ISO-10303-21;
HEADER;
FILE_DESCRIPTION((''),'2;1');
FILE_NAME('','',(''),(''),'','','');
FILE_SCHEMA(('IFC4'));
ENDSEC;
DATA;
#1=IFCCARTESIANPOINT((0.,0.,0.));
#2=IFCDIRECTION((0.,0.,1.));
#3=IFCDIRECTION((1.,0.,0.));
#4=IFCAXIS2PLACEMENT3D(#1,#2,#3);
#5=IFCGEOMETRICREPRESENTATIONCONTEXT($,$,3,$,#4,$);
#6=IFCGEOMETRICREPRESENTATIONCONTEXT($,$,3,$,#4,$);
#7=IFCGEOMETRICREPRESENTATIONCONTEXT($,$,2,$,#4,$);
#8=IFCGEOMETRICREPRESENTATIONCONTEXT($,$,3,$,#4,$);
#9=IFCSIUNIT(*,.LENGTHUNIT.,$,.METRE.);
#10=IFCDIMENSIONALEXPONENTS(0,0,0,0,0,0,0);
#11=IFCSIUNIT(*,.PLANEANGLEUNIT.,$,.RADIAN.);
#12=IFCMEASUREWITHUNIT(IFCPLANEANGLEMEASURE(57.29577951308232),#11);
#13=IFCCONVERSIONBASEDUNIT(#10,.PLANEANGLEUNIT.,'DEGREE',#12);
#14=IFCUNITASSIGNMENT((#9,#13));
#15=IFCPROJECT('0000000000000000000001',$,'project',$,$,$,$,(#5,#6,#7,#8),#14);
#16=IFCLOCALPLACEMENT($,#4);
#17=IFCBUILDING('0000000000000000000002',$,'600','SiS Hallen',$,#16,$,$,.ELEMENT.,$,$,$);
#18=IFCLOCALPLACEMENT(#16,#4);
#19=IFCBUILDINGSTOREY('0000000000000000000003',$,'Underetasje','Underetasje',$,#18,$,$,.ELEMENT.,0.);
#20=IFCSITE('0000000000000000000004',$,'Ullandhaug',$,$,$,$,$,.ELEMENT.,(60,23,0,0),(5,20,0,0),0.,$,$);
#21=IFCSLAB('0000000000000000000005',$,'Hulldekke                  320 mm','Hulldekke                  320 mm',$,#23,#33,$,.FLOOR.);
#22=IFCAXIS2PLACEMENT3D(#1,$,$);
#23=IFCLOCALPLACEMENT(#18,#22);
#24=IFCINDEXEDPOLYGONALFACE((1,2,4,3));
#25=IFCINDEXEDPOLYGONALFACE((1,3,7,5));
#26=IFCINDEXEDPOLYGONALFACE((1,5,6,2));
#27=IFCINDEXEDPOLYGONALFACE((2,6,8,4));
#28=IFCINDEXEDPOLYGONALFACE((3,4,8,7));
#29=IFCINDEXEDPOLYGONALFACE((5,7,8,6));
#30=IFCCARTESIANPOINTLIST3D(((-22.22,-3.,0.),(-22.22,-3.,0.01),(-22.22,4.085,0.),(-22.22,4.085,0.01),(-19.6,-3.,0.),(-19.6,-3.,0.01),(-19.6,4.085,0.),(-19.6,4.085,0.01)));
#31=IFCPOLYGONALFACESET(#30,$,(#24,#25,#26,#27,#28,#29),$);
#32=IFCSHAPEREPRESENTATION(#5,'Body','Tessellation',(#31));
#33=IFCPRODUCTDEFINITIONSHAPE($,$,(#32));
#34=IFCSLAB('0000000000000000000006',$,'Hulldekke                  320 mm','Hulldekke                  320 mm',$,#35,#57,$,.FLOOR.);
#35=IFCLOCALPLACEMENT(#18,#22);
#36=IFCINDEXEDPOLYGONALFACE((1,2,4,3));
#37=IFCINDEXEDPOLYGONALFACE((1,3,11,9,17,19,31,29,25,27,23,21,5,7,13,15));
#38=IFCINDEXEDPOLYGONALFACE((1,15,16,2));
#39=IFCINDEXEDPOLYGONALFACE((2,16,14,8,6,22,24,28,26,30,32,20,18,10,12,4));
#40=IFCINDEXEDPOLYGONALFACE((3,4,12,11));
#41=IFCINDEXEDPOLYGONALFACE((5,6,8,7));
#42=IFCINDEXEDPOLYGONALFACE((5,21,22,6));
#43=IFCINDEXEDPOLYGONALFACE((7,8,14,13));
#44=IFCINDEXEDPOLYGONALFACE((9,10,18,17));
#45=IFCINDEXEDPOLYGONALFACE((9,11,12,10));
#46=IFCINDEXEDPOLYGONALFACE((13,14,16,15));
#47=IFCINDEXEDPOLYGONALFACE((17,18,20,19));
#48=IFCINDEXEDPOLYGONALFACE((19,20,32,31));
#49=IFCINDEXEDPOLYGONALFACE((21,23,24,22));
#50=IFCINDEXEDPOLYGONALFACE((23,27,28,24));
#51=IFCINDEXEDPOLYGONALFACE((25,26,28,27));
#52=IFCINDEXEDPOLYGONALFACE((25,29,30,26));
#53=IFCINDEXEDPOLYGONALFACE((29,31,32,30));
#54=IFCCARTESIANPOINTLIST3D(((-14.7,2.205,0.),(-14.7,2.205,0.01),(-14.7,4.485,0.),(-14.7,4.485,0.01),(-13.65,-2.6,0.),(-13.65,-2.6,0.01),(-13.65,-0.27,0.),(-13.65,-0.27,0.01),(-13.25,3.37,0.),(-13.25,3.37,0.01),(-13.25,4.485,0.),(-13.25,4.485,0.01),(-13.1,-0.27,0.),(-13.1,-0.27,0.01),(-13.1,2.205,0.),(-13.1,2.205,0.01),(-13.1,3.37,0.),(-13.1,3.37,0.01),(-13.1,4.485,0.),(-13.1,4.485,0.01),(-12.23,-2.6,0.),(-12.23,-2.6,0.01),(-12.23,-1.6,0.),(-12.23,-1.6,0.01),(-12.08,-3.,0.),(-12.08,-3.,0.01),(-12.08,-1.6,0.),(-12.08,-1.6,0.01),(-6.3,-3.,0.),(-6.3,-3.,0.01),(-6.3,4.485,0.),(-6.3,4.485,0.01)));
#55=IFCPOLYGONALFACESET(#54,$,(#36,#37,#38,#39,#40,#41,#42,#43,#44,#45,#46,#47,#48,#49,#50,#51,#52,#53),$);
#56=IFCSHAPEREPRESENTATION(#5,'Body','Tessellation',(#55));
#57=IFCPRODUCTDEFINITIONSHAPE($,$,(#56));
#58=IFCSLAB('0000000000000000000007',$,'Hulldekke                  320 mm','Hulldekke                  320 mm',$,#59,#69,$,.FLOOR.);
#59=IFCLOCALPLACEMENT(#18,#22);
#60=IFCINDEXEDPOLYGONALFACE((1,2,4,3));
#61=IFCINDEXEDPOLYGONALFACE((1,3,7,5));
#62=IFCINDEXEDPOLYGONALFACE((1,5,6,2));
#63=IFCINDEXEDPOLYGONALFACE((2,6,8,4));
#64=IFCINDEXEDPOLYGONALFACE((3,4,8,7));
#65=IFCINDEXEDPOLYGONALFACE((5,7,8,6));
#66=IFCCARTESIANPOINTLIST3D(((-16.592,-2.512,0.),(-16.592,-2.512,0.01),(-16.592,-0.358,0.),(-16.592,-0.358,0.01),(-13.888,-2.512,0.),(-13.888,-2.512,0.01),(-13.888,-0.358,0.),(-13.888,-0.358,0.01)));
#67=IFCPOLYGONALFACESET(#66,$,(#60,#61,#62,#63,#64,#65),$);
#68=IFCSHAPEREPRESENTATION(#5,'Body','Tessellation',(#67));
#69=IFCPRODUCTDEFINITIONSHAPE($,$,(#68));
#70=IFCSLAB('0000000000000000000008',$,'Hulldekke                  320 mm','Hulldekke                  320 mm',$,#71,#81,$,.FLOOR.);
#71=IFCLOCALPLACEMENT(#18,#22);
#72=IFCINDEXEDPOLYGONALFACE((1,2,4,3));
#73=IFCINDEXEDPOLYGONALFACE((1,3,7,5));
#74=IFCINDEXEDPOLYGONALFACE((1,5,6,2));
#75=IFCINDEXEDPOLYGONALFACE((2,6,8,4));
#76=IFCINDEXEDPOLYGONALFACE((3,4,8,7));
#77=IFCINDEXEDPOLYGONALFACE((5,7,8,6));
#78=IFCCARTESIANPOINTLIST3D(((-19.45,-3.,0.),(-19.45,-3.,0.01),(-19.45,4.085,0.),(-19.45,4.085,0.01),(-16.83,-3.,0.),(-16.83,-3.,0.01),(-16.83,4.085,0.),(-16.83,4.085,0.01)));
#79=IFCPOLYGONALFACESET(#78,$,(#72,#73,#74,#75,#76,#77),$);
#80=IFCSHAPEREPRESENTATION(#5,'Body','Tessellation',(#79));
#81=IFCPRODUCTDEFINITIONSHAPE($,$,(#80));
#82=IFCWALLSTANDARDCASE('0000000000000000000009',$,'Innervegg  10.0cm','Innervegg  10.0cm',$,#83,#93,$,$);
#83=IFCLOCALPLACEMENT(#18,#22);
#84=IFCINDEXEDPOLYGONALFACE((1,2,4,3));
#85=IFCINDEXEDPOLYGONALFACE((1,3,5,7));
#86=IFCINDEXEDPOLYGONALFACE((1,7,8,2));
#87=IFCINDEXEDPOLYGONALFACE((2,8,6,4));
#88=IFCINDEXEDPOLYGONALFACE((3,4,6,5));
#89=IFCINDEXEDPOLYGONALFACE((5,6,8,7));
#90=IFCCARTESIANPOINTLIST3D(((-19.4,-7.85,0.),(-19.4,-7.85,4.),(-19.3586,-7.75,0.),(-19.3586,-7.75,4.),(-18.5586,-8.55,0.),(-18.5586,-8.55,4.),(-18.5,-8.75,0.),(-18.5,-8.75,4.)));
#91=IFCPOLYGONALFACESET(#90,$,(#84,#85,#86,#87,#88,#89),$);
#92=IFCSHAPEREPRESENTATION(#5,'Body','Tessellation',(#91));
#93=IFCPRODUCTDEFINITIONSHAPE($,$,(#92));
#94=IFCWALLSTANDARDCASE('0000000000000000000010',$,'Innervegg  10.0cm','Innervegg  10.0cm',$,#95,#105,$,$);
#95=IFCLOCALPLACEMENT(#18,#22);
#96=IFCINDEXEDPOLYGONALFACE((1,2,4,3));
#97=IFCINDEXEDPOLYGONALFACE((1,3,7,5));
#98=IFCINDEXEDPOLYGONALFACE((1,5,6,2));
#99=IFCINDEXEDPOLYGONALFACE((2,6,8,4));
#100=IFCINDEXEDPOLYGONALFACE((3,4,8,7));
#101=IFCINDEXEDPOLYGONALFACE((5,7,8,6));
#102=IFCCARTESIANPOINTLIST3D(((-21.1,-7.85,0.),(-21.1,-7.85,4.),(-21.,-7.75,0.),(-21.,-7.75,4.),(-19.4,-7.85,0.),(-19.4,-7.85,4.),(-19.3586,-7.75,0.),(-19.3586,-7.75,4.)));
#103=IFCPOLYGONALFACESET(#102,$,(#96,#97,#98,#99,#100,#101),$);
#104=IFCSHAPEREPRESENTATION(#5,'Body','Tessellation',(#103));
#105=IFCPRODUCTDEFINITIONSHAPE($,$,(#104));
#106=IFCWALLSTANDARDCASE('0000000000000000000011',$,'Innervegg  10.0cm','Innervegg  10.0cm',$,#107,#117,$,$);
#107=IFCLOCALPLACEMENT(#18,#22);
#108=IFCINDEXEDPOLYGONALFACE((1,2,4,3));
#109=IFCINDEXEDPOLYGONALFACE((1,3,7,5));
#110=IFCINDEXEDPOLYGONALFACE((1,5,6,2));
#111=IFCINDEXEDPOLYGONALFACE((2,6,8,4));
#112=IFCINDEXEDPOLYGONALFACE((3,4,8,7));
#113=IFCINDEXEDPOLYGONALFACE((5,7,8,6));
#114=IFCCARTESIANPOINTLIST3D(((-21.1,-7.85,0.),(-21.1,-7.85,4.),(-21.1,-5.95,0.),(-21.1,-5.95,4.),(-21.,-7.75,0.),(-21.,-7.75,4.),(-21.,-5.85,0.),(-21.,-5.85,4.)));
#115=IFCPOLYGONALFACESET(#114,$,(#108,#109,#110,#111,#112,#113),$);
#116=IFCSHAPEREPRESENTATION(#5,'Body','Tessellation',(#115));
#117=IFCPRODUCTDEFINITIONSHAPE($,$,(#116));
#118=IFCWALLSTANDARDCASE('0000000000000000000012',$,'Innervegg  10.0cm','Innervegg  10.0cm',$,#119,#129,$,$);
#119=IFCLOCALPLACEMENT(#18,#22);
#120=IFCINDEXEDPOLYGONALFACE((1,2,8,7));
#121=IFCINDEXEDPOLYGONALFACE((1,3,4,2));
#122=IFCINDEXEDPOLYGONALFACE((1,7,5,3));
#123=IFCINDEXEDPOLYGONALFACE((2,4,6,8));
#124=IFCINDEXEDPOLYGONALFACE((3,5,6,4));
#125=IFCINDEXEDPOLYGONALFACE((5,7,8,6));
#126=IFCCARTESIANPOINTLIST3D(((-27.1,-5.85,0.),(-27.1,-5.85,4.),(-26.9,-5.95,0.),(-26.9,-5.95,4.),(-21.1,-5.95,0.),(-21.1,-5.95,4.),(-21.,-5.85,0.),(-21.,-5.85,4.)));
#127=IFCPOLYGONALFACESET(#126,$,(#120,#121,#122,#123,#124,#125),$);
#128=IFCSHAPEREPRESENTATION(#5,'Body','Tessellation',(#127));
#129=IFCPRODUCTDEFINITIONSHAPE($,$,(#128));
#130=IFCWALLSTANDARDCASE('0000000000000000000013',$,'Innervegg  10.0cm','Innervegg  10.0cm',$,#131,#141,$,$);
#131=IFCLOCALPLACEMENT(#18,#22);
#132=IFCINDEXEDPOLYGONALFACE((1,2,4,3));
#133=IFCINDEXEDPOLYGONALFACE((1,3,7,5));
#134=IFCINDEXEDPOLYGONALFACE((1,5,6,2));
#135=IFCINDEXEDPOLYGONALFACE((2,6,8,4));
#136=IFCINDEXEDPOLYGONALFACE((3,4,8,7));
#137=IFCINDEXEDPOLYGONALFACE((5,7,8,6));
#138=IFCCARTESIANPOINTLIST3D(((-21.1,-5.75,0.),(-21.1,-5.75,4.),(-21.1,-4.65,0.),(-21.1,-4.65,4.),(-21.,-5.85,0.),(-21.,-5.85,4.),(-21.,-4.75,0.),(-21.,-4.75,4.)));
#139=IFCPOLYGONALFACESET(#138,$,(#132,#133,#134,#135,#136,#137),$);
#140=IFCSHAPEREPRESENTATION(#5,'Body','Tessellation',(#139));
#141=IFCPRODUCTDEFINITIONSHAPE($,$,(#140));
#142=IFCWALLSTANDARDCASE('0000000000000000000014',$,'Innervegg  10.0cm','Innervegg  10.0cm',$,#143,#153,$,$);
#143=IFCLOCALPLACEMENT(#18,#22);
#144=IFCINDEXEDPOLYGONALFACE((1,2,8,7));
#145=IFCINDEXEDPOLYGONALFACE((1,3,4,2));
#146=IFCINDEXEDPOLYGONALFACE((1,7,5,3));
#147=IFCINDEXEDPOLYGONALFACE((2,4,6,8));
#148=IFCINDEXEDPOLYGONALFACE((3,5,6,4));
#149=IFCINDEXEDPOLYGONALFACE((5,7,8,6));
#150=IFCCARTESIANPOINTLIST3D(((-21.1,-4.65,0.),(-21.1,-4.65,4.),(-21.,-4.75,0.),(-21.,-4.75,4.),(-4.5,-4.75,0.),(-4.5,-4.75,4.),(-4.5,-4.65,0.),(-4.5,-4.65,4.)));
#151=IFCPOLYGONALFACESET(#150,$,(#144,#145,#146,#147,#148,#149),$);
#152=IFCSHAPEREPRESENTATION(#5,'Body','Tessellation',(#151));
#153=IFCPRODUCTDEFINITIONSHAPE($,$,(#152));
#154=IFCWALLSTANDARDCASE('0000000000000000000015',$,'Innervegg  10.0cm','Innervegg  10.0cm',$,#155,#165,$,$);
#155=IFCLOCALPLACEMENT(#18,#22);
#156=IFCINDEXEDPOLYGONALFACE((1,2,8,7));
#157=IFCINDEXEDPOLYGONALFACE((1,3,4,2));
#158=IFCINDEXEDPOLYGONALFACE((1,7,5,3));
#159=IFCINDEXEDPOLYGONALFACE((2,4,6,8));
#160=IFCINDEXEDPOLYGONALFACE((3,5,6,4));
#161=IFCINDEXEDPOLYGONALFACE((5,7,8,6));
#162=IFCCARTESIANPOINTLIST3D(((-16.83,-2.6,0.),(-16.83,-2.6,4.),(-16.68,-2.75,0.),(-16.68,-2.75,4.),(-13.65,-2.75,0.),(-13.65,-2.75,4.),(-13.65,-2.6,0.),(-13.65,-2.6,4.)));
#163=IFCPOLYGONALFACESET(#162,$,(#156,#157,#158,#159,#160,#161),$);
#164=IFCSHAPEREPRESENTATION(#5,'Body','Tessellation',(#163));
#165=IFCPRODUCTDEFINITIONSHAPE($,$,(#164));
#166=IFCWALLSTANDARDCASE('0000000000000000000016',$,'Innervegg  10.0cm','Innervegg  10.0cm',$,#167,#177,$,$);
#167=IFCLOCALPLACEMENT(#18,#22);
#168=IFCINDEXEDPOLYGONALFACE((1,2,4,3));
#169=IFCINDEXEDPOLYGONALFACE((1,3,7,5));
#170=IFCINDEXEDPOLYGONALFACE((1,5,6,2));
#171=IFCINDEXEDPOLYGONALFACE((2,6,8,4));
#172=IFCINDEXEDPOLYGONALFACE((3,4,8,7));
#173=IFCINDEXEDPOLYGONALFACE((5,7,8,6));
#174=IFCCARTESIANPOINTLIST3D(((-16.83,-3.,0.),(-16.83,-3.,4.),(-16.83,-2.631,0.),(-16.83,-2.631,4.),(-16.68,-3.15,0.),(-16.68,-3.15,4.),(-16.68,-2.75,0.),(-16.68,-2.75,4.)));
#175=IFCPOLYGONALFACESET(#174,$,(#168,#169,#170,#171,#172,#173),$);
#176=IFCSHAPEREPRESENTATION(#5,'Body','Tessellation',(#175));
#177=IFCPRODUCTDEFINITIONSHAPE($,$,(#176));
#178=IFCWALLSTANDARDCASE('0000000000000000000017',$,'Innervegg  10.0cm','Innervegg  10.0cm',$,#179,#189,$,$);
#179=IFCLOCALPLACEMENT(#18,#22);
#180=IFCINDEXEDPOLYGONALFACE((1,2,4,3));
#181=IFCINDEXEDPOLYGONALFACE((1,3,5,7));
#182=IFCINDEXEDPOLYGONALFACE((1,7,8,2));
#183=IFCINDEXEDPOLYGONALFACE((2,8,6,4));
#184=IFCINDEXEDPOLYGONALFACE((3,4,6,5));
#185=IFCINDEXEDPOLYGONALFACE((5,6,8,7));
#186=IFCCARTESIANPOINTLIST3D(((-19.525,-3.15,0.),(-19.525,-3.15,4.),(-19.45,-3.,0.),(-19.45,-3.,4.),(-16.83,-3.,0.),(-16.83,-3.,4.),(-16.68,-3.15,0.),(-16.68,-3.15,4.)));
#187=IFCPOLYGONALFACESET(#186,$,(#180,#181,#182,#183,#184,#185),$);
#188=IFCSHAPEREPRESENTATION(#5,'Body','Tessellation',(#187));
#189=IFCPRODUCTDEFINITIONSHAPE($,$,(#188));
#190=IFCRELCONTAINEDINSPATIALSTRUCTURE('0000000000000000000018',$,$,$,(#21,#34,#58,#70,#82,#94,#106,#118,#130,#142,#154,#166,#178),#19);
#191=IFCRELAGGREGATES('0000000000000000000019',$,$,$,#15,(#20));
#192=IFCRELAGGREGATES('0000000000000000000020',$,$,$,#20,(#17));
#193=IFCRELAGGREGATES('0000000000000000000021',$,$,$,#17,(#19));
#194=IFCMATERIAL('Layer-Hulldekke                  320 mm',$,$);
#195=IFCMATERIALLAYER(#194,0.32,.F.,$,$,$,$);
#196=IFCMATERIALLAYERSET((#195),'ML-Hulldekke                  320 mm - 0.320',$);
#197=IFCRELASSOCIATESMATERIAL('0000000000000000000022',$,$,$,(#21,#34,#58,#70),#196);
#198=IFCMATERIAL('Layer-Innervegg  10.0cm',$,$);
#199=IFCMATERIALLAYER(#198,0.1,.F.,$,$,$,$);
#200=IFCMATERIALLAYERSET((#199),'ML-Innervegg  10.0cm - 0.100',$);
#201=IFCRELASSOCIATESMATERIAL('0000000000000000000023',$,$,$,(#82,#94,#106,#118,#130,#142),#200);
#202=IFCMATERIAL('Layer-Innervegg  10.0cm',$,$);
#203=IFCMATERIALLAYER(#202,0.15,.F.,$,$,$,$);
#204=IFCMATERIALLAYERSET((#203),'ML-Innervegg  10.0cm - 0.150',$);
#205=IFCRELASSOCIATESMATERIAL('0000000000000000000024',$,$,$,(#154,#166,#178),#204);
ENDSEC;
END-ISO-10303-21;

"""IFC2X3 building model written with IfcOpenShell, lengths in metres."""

from ifc_helpers import new_model, entity, si_unit, converted_unit, frame, origin_with_axes, place, context, project, spatial, polyline, outline, extrude, material, layer, layer_set, layer_usage, element, save


model = new_model("IFC2X3")

# Units and contexts
context_of_model_1 = context(None, 3, world=origin_with_axes())
context_of_model_2 = context(None, 3, world=origin_with_axes())
context_of_model_3 = context(None, 2, world=origin_with_axes())
context_of_model_4 = context(None, 3, world=origin_with_axes())
ifc_project = project(units=[si_unit("LENGTHUNIT", "METRE"), converted_unit("PLANEANGLEUNIT", "DEGREE", entity("IfcPlaneAngleMeasure", 57.29577951308232), si_unit("PLANEANGLEUNIT", "RADIAN"), dimensions=[0, 0, 0, 0, 0, 0, 0])], contexts=[context_of_model_1, context_of_model_2, context_of_model_3, context_of_model_4])

# Site, building, storey
site = spatial("IfcSite", under=ifc_project, Name="Ullandhaug", CompositionType="ELEMENT", RefLatitude=(60, 23, 0, 0), RefLongitude=(5, 20, 0, 0), RefElevation=0.0)
building_placement = place(None, origin_with_axes())
building = spatial("IfcBuilding", under=site, at=building_placement, Name="600", Description="SiS Hallen", CompositionType="ELEMENT")
storey_placement = place(building_placement, origin_with_axes())
storey = spatial("IfcBuildingStorey", under=building, at=storey_placement, Name="Underetasje", Description="Underetasje", CompositionType="ELEMENT", Elevation=0.0)

# Slabs
ifc_material_1 = material(Name="Layer-Hulldekke                  320 mm")
ifc_layer_1 = layer(ifc_material_1, 0.32, ventilated=False)
ifc_layer_set_1 = layer_set([ifc_layer_1], Name="ML-Hulldekke                  320 mm - 0.320")
ifc_layer_usage_1 = layer_usage(ifc_layer_set_1, "AXIS2", "POSITIVE", 0.0)
slab_1_placement = place(storey_placement, frame((-22.22, -3.0, 0.0), z_axis=(0.0, 0.0, 1.0), x_axis=(1.0, 0.0, 0.0)))
element("IfcSlab", 1, at=slab_1_placement, inside=storey, material=ifc_layer_usage_1, Name="Hulldekke                  320 mm", Description="Hulldekke                  320 mm", PredefinedType="FLOOR", context=context_of_model_1, shape_type="SweptSolid", body=[
    extrude(outline(polyline([(0.0, 0.0), (2.62, 0.0), (2.62, 7.085), (0.0, 7.085), (0.0, 0.0)])), origin_with_axes(), (0.0, 0.0, 1.0), 0.01),
])
slab_2_placement = place(storey_placement, frame((-13.65, -2.6, 0.0), z_axis=(0.0, 0.0, 1.0), x_axis=(1.0, 0.0, 0.0)))
element("IfcSlab", 2, at=slab_2_placement, inside=storey, material=ifc_layer_usage_1, Name="Hulldekke                  320 mm", Description="Hulldekke                  320 mm", PredefinedType="FLOOR", context=context_of_model_1, shape_type="SweptSolid", body=[
    extrude(outline(polyline([(0.0, 0.0), (1.42, 0.0), (1.42, 1.0), (1.57, 1.0), (1.57, -0.4), (7.35, -0.4), (7.35, 7.085), (0.55, 7.085), (0.55, 5.97), (0.4, 5.97), (0.4, 7.085), (-1.05, 7.085), (-1.05, 4.805), (0.55, 4.805), (0.55, 2.33), (0.0, 2.33), (0.0, 0.0)])), origin_with_axes(), (0.0, 0.0, 1.0), 0.01),
])
slab_3_placement = place(storey_placement, frame((-16.592, -2.512, 0.0), z_axis=(0.0, 0.0, 1.0), x_axis=(1.0, 0.0, 0.0)))
element("IfcSlab", 3, at=slab_3_placement, inside=storey, material=ifc_layer_usage_1, Name="Hulldekke                  320 mm", Description="Hulldekke                  320 mm", PredefinedType="FLOOR", context=context_of_model_1, shape_type="SweptSolid", body=[
    extrude(outline(polyline([(0.0, 0.0), (2.704, 0.0), (2.704, 2.154), (0.0, 2.154), (0.0, 0.0)])), origin_with_axes(), (0.0, 0.0, 1.0), 0.01),
])
slab_4_placement = place(storey_placement, frame((-19.45, -3.0, 0.0), z_axis=(0.0, 0.0, 1.0), x_axis=(1.0, 0.0, 0.0)))
element("IfcSlab", 4, at=slab_4_placement, inside=storey, material=ifc_layer_usage_1, Name="Hulldekke                  320 mm", Description="Hulldekke                  320 mm", PredefinedType="FLOOR", context=context_of_model_1, shape_type="SweptSolid", body=[
    extrude(outline(polyline([(0.0, 0.0), (2.62, 0.0), (2.62, 7.085), (0.0, 7.085), (0.0, 0.0)])), origin_with_axes(), (0.0, 0.0, 1.0), 0.01),
])

# Walls
ifc_material_2 = material(Name="Layer-Innervegg  10.0cm")
ifc_layer_2 = layer(ifc_material_2, 0.1, ventilated=False)
ifc_layer_set_2 = layer_set([ifc_layer_2], Name="ML-Innervegg  10.0cm - 0.100")
ifc_layer_usage_2 = layer_usage(ifc_layer_set_2, "AXIS2", "POSITIVE", 0.0)
wall_1_placement = place(storey_placement, frame((-18.5586, -8.55, 0.0), z_axis=(0.0, 0.0, 1.0), x_axis=(-0.707106, 0.707107, 0.0)))
element("IfcWallStandardCase", 5, at=wall_1_placement, inside=storey, material=ifc_layer_usage_2, Name="Innervegg  10.0cm", Description="Innervegg  10.0cm", context=context_of_model_1, shape_type="SweptSolid", body=[
    extrude(outline(polyline([(0.0, 0.0), (1.1314, 0.0), (1.0899, 0.1), (-0.1828, 0.1), (0.0, 0.0)])), frame((0.0, 0.0, 0.0), z_axis=(0.0, 0.0, 1.0), x_axis=(1.0, 0.0, 0.0)), (0.0, 0.0, 1.0), 4.0),
])
wall_2_placement = place(storey_placement, frame((-19.3586, -7.75, 0.0), z_axis=(0.0, 0.0, 1.0), x_axis=(-1.0, 0.0, 0.0)))
element("IfcWallStandardCase", 6, at=wall_2_placement, inside=storey, material=ifc_layer_usage_2, Name="Innervegg  10.0cm", Description="Innervegg  10.0cm", context=context_of_model_1, shape_type="SweptSolid", body=[
    extrude(outline(polyline([(0.0, 0.0), (1.6414, 0.0), (1.7414, 0.1), (0.0414, 0.1), (0.0, 0.0)])), frame((0.0, 0.0, 0.0), z_axis=(0.0, 0.0, 1.0), x_axis=(1.0, 0.0, 0.0)), (0.0, 0.0, 1.0), 4.0),
])
wall_3_placement = place(storey_placement, frame((-21.0, -7.75, 0.0), z_axis=(0.0, 0.0, 1.0), x_axis=(0.0, 1.0, 0.0)))
element("IfcWallStandardCase", 7, at=wall_3_placement, inside=storey, material=ifc_layer_usage_2, Name="Innervegg  10.0cm", Description="Innervegg  10.0cm", context=context_of_model_1, shape_type="SweptSolid", body=[
    extrude(outline(polyline([(0.0, 0.0), (1.9, 0.0), (1.8, 0.1), (-0.1, 0.1), (0.0, 0.0)])), frame((0.0, 0.0, 0.0), z_axis=(0.0, 0.0, 1.0), x_axis=(1.0, 0.0, 0.0)), (0.0, 0.0, 1.0), 4.0),
])
wall_4_placement = place(storey_placement, frame((-21.0, -5.85, 0.0), z_axis=(0.0, 0.0, 1.0), x_axis=(-1.0, 0.0, 0.0)))
element("IfcWallStandardCase", 8, at=wall_4_placement, inside=storey, material=ifc_layer_usage_2, Name="Innervegg  10.0cm", Description="Innervegg  10.0cm", context=context_of_model_1, shape_type="SweptSolid", body=[
    extrude(outline(polyline([(0.0, 0.0), (6.1, 0.0), (5.9, 0.1), (0.1, 0.1), (0.0, 0.0)])), frame((0.0, 0.0, 0.0), z_axis=(0.0, 0.0, 1.0), x_axis=(1.0, 0.0, 0.0)), (0.0, 0.0, 1.0), 4.0),
])
wall_5_placement = place(storey_placement, frame((-21.0, -5.85, 0.0), z_axis=(0.0, 0.0, 1.0), x_axis=(0.0, 1.0, 0.0)))
element("IfcWallStandardCase", 9, at=wall_5_placement, inside=storey, material=ifc_layer_usage_2, Name="Innervegg  10.0cm", Description="Innervegg  10.0cm", context=context_of_model_1, shape_type="SweptSolid", body=[
    extrude(outline(polyline([(0.0, 0.0), (1.1, 0.0), (1.2, 0.1), (0.1, 0.1), (0.0, 0.0)])), frame((0.0, 0.0, 0.0), z_axis=(0.0, 0.0, 1.0), x_axis=(1.0, 0.0, 0.0)), (0.0, 0.0, 1.0), 4.0),
])
wall_6_placement = place(storey_placement, frame((-21.0, -4.75, 0.0), z_axis=(0.0, 0.0, 1.0), x_axis=(1.0, 0.0, 0.0)))
element("IfcWallStandardCase", 10, at=wall_6_placement, inside=storey, material=ifc_layer_usage_2, Name="Innervegg  10.0cm", Description="Innervegg  10.0cm", context=context_of_model_1, shape_type="SweptSolid", body=[
    extrude(outline(polyline([(0.0, 0.0), (16.5, 0.0), (16.5, 0.1), (-0.1, 0.1), (0.0, 0.0)])), origin_with_axes(), (0.0, 0.0, 1.0), 4.0),
])
ifc_material_3 = material(Name="Layer-Innervegg  10.0cm")
ifc_layer_3 = layer(ifc_material_3, 0.15, ventilated=False)
ifc_layer_set_3 = layer_set([ifc_layer_3], Name="ML-Innervegg  10.0cm - 0.150")
ifc_layer_usage_3 = layer_usage(ifc_layer_set_3, "AXIS2", "POSITIVE", 0.0)
wall_7_placement = place(storey_placement, frame((-13.65, -2.6, 0.0), z_axis=(0.0, 0.0, 1.0), x_axis=(-1.0, 0.0, 0.0)))
element("IfcWallStandardCase", 11, at=wall_7_placement, inside=storey, material=ifc_layer_usage_3, Name="Innervegg  10.0cm", Description="Innervegg  10.0cm", context=context_of_model_1, shape_type="SweptSolid", body=[
    extrude(outline(polyline([(0.0, 0.0), (3.18, 0.0), (3.03, 0.15), (0.0, 0.15), (0.0, 0.0)])), frame((0.0, 0.0, 0.0), z_axis=(0.0, 0.0, 1.0), x_axis=(1.0, 0.0, 0.0)), (0.0, 0.0, 1.0), 4.0),
])
wall_8_placement = place(storey_placement, frame((-16.83, -2.631, 0.0), z_axis=(0.0, 0.0, 1.0), x_axis=(0.0, -1.0, 0.0)))
element("IfcWallStandardCase", 12, at=wall_8_placement, inside=storey, material=ifc_layer_usage_3, Name="Innervegg  10.0cm", Description="Innervegg  10.0cm", context=context_of_model_1, shape_type="SweptSolid", body=[
    extrude(outline(polyline([(0.0, 0.0), (0.369, 0.0), (0.519, 0.15), (0.119, 0.15), (0.0, 0.0)])), frame((0.0, 0.0, 0.0), z_axis=(0.0, 0.0, 1.0), x_axis=(1.0, 0.0, 0.0)), (0.0, 0.0, 1.0), 4.0),
])
wall_9_placement = place(storey_placement, frame((-16.83, -3.0, 0.0), z_axis=(0.0, 0.0, 1.0), x_axis=(-1.0, 0.0, 0.0)))
element("IfcWallStandardCase", 13, at=wall_9_placement, inside=storey, material=ifc_layer_usage_3, Name="Innervegg  10.0cm", Description="Innervegg  10.0cm", context=context_of_model_1, shape_type="SweptSolid", body=[
    extrude(outline(polyline([(0.0, 0.0), (2.62, 0.0), (2.695, 0.15), (-0.15, 0.15), (0.0, 0.0)])), frame((0.0, 0.0, 0.0), z_axis=(0.0, 0.0, 1.0), x_axis=(1.0, 0.0, 0.0)), (0.0, 0.0, 1.0), 4.0),
])

save(model, "model.ifc")
